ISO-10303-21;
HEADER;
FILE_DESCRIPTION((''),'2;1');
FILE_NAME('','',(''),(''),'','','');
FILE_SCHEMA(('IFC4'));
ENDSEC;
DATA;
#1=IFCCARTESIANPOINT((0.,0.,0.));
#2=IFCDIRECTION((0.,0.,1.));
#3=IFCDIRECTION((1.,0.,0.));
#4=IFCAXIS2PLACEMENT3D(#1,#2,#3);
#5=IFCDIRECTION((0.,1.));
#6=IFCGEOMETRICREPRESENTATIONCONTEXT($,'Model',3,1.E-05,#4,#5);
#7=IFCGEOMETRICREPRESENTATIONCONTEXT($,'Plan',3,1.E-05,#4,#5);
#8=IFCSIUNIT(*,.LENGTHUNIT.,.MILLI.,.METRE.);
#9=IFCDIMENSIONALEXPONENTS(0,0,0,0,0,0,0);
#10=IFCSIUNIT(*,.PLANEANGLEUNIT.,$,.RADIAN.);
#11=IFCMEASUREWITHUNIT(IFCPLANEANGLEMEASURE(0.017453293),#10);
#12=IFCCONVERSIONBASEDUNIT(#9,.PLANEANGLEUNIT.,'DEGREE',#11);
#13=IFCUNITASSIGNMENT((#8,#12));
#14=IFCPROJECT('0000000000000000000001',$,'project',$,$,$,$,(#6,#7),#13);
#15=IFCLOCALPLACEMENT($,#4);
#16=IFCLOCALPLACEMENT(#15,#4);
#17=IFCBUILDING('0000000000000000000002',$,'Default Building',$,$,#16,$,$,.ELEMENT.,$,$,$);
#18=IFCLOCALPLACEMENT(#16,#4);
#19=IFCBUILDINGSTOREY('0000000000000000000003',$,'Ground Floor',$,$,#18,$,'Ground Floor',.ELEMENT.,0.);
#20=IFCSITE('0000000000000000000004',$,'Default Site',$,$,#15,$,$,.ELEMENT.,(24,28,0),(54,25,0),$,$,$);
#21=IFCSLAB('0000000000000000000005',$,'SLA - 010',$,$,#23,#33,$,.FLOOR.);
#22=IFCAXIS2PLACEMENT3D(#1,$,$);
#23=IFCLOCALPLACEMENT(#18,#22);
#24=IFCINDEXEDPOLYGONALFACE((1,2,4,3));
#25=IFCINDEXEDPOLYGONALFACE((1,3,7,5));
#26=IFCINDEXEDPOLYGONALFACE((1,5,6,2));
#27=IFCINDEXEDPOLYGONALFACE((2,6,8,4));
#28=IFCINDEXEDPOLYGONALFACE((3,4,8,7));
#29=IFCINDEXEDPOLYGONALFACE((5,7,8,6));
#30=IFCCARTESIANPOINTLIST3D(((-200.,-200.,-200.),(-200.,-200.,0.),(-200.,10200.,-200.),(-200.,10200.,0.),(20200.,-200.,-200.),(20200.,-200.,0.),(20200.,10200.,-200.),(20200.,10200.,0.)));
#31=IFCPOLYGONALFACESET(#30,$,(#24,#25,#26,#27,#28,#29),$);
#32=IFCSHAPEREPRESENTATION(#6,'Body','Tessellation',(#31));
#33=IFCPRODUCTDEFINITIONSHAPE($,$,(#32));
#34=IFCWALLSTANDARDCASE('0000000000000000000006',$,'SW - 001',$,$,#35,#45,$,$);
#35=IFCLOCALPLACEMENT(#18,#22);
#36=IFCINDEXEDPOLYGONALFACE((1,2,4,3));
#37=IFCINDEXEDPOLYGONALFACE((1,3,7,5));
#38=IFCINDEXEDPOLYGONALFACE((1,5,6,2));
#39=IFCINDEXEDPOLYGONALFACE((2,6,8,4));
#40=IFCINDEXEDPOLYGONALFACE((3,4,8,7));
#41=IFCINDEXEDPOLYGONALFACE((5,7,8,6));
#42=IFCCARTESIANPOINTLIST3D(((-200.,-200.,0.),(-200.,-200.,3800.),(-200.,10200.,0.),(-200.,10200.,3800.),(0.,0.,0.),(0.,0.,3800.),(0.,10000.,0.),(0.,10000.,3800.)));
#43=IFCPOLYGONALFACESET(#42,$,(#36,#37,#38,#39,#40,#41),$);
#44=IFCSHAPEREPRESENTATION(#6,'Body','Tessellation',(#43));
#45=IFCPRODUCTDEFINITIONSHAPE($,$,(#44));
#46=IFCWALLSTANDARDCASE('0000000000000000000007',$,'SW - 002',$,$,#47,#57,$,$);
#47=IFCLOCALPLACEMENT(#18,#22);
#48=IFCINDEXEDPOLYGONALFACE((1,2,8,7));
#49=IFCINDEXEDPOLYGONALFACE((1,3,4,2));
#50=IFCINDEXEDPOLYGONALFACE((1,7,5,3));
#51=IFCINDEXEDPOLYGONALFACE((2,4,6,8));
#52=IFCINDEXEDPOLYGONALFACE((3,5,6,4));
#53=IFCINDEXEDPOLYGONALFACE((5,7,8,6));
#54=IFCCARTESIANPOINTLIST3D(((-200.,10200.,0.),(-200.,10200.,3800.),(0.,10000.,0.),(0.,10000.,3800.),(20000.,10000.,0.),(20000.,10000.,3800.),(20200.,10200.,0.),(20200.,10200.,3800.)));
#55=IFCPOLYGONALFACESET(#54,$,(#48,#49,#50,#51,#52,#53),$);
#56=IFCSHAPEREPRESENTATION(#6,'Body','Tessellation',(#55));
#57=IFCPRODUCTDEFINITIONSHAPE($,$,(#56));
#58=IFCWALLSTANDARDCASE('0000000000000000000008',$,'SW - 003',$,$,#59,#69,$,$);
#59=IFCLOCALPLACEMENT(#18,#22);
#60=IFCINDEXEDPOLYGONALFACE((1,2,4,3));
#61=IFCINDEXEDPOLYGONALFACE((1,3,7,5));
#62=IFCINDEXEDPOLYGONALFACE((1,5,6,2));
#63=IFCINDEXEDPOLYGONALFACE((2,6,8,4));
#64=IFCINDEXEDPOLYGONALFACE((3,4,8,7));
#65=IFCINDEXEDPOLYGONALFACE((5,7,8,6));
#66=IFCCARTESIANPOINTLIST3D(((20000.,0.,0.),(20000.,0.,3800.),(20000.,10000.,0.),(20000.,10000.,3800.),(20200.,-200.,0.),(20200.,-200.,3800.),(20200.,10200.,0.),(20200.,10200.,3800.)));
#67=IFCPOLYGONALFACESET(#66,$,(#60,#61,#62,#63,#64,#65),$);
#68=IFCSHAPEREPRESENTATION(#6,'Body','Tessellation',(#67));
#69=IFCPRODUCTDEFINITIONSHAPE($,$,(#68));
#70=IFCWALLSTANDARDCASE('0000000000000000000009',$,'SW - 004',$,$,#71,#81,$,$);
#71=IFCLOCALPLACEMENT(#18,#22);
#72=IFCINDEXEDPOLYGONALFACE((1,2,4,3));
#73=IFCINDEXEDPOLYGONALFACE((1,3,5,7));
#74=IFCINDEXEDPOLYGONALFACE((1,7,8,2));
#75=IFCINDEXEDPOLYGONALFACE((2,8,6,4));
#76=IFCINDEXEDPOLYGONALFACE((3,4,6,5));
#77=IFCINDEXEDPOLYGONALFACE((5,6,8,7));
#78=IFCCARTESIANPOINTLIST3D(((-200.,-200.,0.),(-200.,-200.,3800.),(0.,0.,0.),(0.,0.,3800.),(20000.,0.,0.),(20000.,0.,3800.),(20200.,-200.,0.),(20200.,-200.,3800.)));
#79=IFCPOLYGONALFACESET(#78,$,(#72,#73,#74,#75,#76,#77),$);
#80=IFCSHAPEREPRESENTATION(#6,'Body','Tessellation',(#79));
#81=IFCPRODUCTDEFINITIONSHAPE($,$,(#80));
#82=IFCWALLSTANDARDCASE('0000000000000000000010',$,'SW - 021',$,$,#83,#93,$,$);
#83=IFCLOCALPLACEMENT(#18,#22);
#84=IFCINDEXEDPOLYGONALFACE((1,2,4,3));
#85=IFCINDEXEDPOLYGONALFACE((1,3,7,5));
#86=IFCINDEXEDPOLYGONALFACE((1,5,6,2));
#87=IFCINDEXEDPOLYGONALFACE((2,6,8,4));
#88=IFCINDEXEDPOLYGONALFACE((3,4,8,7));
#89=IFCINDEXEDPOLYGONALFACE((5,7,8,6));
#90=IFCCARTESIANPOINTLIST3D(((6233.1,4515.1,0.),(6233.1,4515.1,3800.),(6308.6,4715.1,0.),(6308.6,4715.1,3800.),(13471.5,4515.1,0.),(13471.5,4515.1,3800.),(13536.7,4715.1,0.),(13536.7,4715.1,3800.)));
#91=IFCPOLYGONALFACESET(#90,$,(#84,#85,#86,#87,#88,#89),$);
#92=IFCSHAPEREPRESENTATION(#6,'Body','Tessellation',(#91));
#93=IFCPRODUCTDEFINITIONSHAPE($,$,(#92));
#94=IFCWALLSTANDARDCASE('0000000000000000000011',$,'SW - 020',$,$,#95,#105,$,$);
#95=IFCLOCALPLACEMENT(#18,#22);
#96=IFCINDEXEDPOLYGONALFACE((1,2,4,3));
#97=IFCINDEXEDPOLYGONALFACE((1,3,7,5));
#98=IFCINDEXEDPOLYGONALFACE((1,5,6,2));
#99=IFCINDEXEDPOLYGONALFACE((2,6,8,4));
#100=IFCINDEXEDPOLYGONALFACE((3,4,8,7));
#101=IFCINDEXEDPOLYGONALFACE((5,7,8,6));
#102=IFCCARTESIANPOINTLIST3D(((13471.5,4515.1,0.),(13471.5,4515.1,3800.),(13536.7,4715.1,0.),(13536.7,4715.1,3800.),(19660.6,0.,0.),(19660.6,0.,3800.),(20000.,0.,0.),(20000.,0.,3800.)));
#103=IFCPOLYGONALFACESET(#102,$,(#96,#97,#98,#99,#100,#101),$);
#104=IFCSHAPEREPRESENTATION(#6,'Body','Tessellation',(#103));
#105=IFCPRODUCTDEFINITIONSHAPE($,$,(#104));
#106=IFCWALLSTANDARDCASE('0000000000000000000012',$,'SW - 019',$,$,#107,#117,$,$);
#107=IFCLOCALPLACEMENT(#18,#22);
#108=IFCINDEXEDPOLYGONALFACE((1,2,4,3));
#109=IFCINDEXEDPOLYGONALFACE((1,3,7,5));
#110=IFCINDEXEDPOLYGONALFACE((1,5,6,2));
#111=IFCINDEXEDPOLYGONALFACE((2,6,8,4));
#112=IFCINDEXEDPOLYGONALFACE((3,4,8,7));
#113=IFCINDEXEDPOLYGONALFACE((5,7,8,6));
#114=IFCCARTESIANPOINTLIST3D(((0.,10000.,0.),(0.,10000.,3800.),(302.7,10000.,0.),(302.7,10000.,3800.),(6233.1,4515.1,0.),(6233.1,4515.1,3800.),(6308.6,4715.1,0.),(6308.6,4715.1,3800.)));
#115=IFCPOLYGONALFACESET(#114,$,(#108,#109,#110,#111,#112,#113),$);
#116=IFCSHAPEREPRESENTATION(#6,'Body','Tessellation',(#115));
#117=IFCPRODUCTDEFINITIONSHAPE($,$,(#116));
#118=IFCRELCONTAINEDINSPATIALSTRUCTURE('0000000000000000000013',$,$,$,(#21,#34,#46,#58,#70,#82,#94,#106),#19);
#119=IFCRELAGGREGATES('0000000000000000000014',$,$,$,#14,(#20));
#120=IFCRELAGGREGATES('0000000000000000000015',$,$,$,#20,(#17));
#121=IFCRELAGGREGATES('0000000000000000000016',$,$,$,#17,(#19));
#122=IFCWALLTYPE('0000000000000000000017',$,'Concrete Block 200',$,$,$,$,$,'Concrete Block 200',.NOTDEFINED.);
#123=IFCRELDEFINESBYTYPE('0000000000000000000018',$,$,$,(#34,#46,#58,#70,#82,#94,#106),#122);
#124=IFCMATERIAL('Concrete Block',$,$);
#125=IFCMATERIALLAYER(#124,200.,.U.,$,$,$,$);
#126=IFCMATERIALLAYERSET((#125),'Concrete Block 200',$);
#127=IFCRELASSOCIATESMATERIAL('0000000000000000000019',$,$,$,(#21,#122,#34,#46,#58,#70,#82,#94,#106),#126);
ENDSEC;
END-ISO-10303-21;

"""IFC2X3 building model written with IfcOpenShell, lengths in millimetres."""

from ifc_helpers import new_model, entity, si_unit, converted_unit, direction, frame, origin_with_axes, place, context, project, spatial, polyline, outline, extrude, material, layer, layer_set, layer_usage, type_object, element, save


model = new_model("IFC2X3")

# Units and contexts
model_context = context("Model", 3, precision=1e-05, world=origin_with_axes(), true_north=direction((0.0, 1.0)))
plan_context = context("Plan", 3, precision=1e-05, world=origin_with_axes(), true_north=direction((0.0, 1.0)))
ifc_project = project(units=[si_unit("LENGTHUNIT", "METRE", prefix="MILLI"), converted_unit("PLANEANGLEUNIT", "DEGREE", entity("IfcPlaneAngleMeasure", 0.017453293), si_unit("PLANEANGLEUNIT", "RADIAN"), dimensions=[0, 0, 0, 0, 0, 0, 0])], contexts=[model_context, plan_context])

# Site, building, storey
site_placement = place(None, origin_with_axes())
site = spatial("IfcSite", under=ifc_project, at=site_placement, Name="Default Site", CompositionType="ELEMENT", RefLatitude=(24, 28, 0), RefLongitude=(54, 25, 0))
building_placement = place(site_placement, origin_with_axes())
building = spatial("IfcBuilding", under=site, at=building_placement, Name="Default Building", CompositionType="ELEMENT")
storey_placement = place(building_placement, origin_with_axes())
storey = spatial("IfcBuildingStorey", under=building, at=storey_placement, Name="Ground Floor", LongName="Ground Floor", CompositionType="ELEMENT", Elevation=0.0)

# Slab
ifc_material = material(Name="Concrete Block")
ifc_layer = layer(ifc_material, 200.0, ventilated="UNKNOWN")
ifc_layer_set = layer_set([ifc_layer], Name="Concrete Block 200")
ifc_layer_usage_1 = layer_usage(ifc_layer_set, "AXIS3", "NEGATIVE", 200.0)
slab_placement = place(storey_placement, frame((-200.0, 10200.0, -200.0), z_axis=(0.0, 0.0, 1.0), x_axis=(1.0, 0.0, 0.0)))
element("IfcSlab", 1, at=slab_placement, inside=storey, material=ifc_layer_usage_1, Name="SLA - 010", PredefinedType="FLOOR", context=model_context, shape_type="SweptSolid", body=[
    extrude(outline(polyline([(0.0, 0.0), (20400.0, 0.0), (20400.0, -10400.0), (0.0, -10400.0), (0.0, 0.0)])), origin_with_axes(), (0.0, 0.0, 1.0), 200.0),
])

# Walls
ifc_layer_usage_2 = layer_usage(ifc_layer_set, "AXIS2", "POSITIVE", 0.0)
wall_type = type_object("IfcWallType", Name="Concrete Block 200", ElementType="Concrete Block 200", PredefinedType="NOTDEFINED", material=ifc_layer_set)
wall_1_placement = place(storey_placement, frame((0.0, 0.0, 0.0), z_axis=(0.0, 0.0, 1.0), x_axis=(0.0, 1.0, 0.0)))
element("IfcWallStandardCase", 2, at=wall_1_placement, inside=storey, type_object=wall_type, material=ifc_layer_usage_2, Name="SW - 001", context=model_context, shape_type="SweptSolid", body=[
    extrude(outline(polyline([(0.0, 0.0), (10000.0, 0.0), (10200.0, 200.0), (-200.0, 200.0), (0.0, 0.0)])), origin_with_axes(), (0.0, 0.0, 1.0), 3800.0),
])
ifc_layer_usage_3 = layer_usage(ifc_layer_set, "AXIS2", "POSITIVE", 0.0)
wall_2_placement = place(storey_placement, frame((0.0, 10000.0, 0.0), z_axis=(0.0, 0.0, 1.0), x_axis=(1.0, 0.0, 0.0)))
element("IfcWallStandardCase", 3, at=wall_2_placement, inside=storey, type_object=wall_type, material=ifc_layer_usage_3, Name="SW - 002", context=model_context, shape_type="SweptSolid", body=[
    extrude(outline(polyline([(0.0, 0.0), (20000.0, 0.0), (20200.0, 200.0), (-200.0, 200.0), (0.0, 0.0)])), origin_with_axes(), (0.0, 0.0, 1.0), 3800.0),
])
ifc_layer_usage_4 = layer_usage(ifc_layer_set, "AXIS2", "POSITIVE", 0.0)
wall_3_placement = place(storey_placement, frame((20000.0, 10000.0, 0.0), z_axis=(0.0, 0.0, 1.0), x_axis=(0.0, -1.0, 0.0)))
element("IfcWallStandardCase", 4, at=wall_3_placement, inside=storey, type_object=wall_type, material=ifc_layer_usage_4, Name="SW - 003", context=model_context, shape_type="SweptSolid", body=[
    extrude(outline(polyline([(0.0, 0.0), (10000.0, 0.0), (10200.0, 200.0), (-200.0, 200.0), (0.0, 0.0)])), origin_with_axes(), (0.0, 0.0, 1.0), 3800.0),
])
ifc_layer_usage_5 = layer_usage(ifc_layer_set, "AXIS2", "POSITIVE", 0.0)
wall_4_placement = place(storey_placement, frame((20000.0, 0.0, 0.0), z_axis=(0.0, 0.0, 1.0), x_axis=(-1.0, 0.0, 0.0)))
element("IfcWallStandardCase", 5, at=wall_4_placement, inside=storey, type_object=wall_type, material=ifc_layer_usage_5, Name="SW - 004", context=model_context, shape_type="SweptSolid", body=[
    extrude(outline(polyline([(0.0, 0.0), (20000.0, 0.0), (20200.0, 200.0), (-200.0, 200.0), (0.0, 0.0)])), origin_with_axes(), (0.0, 0.0, 1.0), 3800.0),
])
ifc_layer_usage_6 = layer_usage(ifc_layer_set, "AXIS2", "NEGATIVE", 0.0)
wall_5_placement = place(storey_placement, frame((13471.5, 4515.1, 0.0), z_axis=(0.0, 0.0, 1.0), x_axis=(-1.0, 0.0, 0.0)))
element("IfcWallStandardCase", 6, at=wall_5_placement, inside=storey, type_object=wall_type, material=ifc_layer_usage_6, Name="SW - 021", context=model_context, shape_type="SweptSolid", body=[
    extrude(outline(polyline([(-65.2, -200.0), (7162.9, -200.0), (7238.4, 0.0), (0.0, 0.0), (-65.2, -200.0)])), origin_with_axes(), (0.0, 0.0, 1.0), 3800.0),
])
ifc_layer_usage_7 = layer_usage(ifc_layer_set, "AXIS2", "NEGATIVE", 0.0)
wall_6_placement = place(storey_placement, frame((19660.6, 0.0, 0.0), z_axis=(0.0, 0.0, 1.0), x_axis=(-0.807873, 0.589356, 0.0)))
element("IfcWallStandardCase", 7, at=wall_6_placement, inside=storey, type_object=wall_type, material=ifc_layer_usage_7, Name="SW - 020", context=model_context, shape_type="SweptSolid", body=[
    extrude(outline(polyline([(-274.2, -200.0), (7726.2, -200.0), (7661.0, 0.0), (0.0, 0.0), (-274.2, -200.0)])), origin_with_axes(), (0.0, 0.0, 1.0), 3800.0),
])
ifc_layer_usage_8 = layer_usage(ifc_layer_set, "AXIS2", "POSITIVE", 0.0)
wall_7_placement = place(storey_placement, frame((0.0, 10000.0, 0.0), z_axis=(0.0, 0.0, 1.0), x_axis=(0.750727, -0.660613, 0.0)))
element("IfcWallStandardCase", 8, at=wall_7_placement, inside=storey, type_object=wall_type, material=ifc_layer_usage_8, Name="SW - 019", context=model_context, shape_type="SweptSolid", body=[
    extrude(outline(polyline([(0.0, 0.0), (8302.8, 0.0), (8227.3, 200.0), (227.3, 200.0), (0.0, 0.0)])), origin_with_axes(), (0.0, 0.0, 1.0), 3800.0),
])

save(model, "model.ifc")
